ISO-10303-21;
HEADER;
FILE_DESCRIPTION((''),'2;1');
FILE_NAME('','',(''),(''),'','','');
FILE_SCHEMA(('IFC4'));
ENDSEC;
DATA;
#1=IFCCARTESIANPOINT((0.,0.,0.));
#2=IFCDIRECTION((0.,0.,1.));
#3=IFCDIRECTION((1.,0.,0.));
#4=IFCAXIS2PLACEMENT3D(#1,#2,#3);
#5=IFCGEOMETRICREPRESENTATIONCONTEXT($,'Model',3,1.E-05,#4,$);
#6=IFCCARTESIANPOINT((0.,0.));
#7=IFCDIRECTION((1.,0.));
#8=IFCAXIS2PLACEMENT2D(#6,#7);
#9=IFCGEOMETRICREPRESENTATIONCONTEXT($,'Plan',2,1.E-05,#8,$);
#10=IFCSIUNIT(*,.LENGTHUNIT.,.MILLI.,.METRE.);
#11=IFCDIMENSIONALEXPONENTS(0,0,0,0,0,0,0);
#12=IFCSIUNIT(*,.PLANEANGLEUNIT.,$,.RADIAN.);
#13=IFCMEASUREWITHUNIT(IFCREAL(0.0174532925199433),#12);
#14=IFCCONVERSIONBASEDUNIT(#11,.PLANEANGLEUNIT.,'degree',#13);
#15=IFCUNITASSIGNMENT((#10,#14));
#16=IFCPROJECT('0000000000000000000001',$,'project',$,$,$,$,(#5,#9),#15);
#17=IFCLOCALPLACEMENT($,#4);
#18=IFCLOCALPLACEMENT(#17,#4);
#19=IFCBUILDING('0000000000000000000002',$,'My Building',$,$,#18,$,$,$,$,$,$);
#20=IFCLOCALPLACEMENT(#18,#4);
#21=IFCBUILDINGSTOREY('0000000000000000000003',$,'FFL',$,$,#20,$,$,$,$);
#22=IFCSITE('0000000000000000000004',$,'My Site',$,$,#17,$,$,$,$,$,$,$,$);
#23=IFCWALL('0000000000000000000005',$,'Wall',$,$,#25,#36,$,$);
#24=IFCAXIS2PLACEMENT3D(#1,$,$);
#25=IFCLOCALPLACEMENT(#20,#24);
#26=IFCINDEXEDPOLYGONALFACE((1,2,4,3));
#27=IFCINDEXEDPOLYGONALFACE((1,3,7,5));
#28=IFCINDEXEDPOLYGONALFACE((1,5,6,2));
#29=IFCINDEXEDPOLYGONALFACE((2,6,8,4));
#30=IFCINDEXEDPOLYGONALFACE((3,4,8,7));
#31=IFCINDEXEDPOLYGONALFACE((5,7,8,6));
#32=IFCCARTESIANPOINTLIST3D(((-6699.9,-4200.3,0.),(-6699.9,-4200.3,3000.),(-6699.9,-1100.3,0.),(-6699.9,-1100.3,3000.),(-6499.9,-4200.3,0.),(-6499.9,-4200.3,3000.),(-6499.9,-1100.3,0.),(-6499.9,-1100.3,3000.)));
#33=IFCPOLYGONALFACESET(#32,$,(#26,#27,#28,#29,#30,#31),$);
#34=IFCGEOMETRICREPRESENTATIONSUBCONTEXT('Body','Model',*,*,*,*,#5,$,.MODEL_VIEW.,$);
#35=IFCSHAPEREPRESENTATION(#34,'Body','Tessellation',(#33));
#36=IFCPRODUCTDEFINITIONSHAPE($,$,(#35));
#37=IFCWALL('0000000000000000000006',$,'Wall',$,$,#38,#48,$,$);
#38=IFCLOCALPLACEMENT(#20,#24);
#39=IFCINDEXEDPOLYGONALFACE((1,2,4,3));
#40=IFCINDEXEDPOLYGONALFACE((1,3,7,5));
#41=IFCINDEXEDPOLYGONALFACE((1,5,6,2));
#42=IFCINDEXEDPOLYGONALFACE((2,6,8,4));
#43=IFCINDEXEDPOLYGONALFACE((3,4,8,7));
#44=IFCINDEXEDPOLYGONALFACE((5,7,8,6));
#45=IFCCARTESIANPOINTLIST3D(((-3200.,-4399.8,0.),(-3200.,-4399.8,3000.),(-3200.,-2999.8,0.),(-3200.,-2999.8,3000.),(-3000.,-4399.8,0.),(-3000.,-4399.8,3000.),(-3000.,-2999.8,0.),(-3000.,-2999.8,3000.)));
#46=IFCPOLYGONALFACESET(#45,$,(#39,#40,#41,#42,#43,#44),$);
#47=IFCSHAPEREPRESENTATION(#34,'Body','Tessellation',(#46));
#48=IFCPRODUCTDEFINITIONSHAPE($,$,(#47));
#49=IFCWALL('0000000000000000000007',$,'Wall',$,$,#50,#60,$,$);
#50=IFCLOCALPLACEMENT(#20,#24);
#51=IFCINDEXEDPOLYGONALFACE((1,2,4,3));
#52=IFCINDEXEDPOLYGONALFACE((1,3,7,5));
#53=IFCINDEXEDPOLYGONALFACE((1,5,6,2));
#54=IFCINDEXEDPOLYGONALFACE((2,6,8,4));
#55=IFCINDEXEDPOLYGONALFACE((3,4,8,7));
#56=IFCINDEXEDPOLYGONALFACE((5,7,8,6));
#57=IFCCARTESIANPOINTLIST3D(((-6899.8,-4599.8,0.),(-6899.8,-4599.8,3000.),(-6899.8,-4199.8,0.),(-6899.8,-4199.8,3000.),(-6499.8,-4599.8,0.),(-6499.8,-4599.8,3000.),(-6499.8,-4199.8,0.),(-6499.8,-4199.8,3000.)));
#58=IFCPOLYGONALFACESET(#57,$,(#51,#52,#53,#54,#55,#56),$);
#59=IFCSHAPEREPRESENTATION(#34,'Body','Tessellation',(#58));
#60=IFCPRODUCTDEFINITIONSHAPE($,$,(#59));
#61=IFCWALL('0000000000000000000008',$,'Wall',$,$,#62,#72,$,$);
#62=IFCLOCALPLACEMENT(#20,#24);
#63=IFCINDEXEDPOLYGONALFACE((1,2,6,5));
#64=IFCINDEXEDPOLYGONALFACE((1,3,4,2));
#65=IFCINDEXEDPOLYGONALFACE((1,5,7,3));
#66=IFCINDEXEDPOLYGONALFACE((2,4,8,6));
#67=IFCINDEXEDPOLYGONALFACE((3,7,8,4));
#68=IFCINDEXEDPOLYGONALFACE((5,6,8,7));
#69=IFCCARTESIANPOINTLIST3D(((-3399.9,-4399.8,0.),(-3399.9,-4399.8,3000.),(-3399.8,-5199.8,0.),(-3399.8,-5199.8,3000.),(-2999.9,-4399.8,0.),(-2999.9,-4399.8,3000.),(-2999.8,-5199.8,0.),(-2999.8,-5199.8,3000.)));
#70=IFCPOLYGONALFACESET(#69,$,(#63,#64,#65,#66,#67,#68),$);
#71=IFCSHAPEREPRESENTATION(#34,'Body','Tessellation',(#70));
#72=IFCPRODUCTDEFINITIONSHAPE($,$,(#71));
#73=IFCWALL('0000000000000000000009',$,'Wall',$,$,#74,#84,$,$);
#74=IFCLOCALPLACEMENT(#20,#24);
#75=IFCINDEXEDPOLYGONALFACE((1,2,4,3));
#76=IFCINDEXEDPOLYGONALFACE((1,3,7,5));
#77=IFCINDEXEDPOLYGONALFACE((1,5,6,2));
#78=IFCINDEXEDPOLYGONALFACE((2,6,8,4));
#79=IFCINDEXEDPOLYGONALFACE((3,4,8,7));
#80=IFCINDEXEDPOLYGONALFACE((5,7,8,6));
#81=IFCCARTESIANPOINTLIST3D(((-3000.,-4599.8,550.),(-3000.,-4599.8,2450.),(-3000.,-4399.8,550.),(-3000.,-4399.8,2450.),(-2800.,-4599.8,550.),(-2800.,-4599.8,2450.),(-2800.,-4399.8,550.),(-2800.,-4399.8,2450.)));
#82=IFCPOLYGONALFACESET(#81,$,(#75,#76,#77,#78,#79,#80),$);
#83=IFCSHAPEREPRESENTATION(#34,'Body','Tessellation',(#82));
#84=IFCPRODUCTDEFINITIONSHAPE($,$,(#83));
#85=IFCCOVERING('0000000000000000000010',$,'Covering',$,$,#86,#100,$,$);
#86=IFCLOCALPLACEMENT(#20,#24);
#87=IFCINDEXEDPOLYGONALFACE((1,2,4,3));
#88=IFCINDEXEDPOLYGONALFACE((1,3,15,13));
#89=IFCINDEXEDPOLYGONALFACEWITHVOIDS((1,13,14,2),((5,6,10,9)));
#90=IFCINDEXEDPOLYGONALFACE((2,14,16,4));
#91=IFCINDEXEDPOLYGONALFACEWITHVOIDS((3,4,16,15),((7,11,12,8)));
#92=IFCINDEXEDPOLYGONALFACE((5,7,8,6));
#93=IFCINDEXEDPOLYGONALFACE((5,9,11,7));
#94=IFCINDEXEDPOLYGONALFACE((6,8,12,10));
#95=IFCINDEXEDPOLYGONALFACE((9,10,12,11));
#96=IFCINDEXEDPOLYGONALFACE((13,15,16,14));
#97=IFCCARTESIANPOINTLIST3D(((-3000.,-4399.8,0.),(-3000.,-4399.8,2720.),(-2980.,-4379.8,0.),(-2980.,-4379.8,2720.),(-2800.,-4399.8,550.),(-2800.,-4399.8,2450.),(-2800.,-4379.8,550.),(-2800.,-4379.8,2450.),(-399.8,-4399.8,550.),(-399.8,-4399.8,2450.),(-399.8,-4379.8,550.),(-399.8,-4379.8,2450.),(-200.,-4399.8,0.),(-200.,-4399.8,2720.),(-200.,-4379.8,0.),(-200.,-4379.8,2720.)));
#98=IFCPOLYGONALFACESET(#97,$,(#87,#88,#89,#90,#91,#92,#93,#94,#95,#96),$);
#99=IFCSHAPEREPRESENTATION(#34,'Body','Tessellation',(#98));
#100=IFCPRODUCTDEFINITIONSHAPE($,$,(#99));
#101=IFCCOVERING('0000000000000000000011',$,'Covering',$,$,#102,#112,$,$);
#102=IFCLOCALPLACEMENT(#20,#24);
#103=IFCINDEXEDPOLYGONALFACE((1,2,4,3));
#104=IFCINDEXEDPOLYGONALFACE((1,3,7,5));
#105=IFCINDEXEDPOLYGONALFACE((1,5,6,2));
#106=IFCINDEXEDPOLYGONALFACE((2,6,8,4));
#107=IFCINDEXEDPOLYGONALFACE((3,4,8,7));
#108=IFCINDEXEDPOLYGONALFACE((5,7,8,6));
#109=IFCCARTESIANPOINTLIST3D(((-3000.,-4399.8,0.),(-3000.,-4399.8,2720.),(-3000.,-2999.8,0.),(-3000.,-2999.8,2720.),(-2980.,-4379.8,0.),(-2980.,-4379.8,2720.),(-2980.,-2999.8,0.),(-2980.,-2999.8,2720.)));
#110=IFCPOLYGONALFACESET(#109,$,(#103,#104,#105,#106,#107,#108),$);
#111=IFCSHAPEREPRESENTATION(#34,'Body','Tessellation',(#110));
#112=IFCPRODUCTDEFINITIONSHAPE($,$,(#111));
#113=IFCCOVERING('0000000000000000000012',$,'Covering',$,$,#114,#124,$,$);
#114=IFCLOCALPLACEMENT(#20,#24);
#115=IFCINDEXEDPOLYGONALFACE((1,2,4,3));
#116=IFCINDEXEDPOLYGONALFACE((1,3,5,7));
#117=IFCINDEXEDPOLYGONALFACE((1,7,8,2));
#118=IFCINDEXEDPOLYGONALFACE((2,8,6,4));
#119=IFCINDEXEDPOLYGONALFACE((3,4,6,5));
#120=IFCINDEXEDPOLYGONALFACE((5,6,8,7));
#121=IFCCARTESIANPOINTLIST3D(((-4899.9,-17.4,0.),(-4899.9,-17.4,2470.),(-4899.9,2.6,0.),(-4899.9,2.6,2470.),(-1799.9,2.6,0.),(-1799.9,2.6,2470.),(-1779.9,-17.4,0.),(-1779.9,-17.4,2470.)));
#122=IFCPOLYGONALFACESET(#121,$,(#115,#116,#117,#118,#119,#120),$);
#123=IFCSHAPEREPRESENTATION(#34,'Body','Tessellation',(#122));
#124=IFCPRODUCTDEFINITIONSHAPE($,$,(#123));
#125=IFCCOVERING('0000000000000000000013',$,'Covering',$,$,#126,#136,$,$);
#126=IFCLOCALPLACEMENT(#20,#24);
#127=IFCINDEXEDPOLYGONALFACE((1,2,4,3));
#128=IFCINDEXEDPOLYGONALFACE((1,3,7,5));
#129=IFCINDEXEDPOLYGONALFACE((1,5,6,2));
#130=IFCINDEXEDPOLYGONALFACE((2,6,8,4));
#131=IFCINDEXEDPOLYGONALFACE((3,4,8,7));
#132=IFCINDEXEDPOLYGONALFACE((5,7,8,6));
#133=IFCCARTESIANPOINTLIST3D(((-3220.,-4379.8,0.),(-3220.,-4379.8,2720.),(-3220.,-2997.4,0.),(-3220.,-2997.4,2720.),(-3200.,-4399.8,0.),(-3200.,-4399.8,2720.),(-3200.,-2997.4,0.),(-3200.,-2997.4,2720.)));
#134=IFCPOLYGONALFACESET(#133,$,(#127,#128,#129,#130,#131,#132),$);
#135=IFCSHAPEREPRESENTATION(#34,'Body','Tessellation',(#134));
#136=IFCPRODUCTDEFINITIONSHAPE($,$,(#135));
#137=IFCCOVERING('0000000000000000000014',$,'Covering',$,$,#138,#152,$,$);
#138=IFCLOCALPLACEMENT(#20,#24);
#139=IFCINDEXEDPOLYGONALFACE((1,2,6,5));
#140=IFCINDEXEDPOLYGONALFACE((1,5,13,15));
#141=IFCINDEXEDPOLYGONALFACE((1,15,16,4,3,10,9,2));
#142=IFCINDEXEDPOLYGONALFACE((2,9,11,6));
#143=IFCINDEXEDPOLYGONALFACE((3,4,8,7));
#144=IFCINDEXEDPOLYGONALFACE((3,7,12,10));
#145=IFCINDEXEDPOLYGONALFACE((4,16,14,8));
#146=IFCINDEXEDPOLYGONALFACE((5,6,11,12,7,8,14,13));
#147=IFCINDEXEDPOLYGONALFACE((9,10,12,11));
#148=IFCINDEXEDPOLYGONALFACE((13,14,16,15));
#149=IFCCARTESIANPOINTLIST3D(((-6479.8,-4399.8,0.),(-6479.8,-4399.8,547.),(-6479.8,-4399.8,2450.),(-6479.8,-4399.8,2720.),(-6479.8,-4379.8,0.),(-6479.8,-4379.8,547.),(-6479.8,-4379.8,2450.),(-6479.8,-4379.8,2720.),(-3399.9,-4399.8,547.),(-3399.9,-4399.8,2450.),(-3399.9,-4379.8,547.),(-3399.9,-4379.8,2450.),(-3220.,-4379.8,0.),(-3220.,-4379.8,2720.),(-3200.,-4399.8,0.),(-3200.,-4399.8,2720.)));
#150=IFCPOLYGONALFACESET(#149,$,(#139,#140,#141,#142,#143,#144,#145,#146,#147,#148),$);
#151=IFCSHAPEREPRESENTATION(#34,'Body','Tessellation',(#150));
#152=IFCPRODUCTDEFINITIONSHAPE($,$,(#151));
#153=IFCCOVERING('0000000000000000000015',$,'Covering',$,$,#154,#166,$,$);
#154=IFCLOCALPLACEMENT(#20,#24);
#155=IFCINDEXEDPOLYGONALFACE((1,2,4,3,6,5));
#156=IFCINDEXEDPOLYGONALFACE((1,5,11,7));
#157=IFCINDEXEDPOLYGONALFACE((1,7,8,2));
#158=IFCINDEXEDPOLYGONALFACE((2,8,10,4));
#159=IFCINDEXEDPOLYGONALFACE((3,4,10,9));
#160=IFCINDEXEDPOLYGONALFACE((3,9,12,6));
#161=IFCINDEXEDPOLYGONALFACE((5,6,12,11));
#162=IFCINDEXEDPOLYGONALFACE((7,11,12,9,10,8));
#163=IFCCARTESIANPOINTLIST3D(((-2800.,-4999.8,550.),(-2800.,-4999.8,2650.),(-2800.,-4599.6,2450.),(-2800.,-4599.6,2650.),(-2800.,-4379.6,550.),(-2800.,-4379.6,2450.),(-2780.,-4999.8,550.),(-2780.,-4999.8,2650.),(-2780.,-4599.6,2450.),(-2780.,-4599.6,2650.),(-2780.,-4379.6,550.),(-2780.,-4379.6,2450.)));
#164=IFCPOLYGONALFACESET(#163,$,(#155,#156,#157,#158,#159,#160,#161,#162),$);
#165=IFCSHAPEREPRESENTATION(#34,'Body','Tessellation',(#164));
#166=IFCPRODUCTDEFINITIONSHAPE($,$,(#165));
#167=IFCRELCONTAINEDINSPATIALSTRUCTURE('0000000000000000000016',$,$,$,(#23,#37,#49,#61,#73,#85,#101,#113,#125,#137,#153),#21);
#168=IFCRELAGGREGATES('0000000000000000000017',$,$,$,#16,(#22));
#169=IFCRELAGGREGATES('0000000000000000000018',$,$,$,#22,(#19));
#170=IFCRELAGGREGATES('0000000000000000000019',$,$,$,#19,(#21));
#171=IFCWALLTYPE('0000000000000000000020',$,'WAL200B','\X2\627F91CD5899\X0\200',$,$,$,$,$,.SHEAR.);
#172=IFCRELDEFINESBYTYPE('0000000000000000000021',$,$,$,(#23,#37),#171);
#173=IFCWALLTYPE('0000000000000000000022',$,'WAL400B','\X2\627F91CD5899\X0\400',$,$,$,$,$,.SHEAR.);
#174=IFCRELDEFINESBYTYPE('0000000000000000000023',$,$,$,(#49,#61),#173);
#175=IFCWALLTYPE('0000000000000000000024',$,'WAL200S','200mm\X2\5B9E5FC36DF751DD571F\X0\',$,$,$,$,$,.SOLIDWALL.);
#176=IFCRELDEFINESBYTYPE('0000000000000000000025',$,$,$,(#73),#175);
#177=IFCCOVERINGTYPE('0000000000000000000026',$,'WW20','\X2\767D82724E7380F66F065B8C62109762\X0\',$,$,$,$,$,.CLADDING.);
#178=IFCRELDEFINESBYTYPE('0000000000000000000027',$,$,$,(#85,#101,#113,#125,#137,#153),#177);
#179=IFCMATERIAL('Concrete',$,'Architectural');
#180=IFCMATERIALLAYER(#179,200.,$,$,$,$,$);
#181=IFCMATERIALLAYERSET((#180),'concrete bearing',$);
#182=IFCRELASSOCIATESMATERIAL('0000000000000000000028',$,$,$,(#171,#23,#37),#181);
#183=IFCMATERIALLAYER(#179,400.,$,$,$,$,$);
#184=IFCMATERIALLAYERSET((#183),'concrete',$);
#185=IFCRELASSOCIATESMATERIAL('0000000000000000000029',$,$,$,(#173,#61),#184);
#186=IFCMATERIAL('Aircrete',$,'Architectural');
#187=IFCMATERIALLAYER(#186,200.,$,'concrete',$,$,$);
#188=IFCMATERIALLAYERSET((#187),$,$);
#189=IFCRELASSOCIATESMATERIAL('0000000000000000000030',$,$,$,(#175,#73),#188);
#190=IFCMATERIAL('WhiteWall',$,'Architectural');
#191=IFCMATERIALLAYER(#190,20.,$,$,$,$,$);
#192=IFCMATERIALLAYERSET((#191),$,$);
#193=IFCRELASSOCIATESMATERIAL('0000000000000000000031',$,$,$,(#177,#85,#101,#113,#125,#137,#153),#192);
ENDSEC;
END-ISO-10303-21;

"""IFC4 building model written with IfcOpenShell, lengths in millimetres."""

from ifc_helpers import new_model, entity, si_unit, converted_unit, frame, origin_with_axes, origin_2d_with_axis, place, context, subcontext, project, spatial, line, indexed_curve, outline, extrude, material, layer, layer_set, layer_usage, type_object, element, save


model = new_model("IFC4")

# Units and contexts
model_context = context("Model", 3, precision=1e-05, world=origin_with_axes())
plan_context = context("Plan", 2, precision=1e-05, world=origin_2d_with_axis())
body_context_1 = subcontext(model_context, "Body", "Model", "MODEL_VIEW")
ifc_project = project(units=[si_unit("LENGTHUNIT", "METRE", prefix="MILLI"), converted_unit("PLANEANGLEUNIT", "degree", entity("IfcReal", 0.0174532925199433), si_unit("PLANEANGLEUNIT", "RADIAN"), dimensions=[0, 0, 0, 0, 0, 0, 0])], contexts=[model_context, plan_context])

# Site, building, storey
site_placement = place(None, origin_with_axes())
site = spatial("IfcSite", under=ifc_project, at=site_placement, Name="My Site")
building_placement = place(site_placement, origin_with_axes())
building = spatial("IfcBuilding", under=site, at=building_placement, Name="My Building")
storey_placement = place(building_placement, origin_with_axes())
storey = spatial("IfcBuildingStorey", under=building, at=storey_placement, Name="FFL")

# Shared definitions
ifc_material_1 = material(Name="Aircrete", Category="Architectural")

# Walls
ifc_material_2 = material(Name="Concrete", Category="Architectural")
ifc_layer_1 = layer(ifc_material_2, 200.0)
ifc_layer_set_1 = layer_set([ifc_layer_1], Name="concrete bearing")
wall_type_1 = type_object("IfcWallType", Name="WAL200B", Description="承重墙200", PredefinedType="SHEAR", material=ifc_layer_set_1)
ifc_layer_usage_1 = layer_usage(ifc_layer_set_1, "AXIS2", "NEGATIVE", 0.0)
wall_1_placement = place(storey_placement, frame((-6499.9, -1100.3, 0.0), z_axis=(0.0, 0.0, 1.0), x_axis=(0.0, -1.0, 0.0)))
element("IfcWall", 1, at=wall_1_placement, inside=storey, type_object=wall_type_1, material=ifc_layer_usage_1, Name="Wall", context=body_context_1, shape_type="SweptSolid", body=[
    extrude(outline(indexed_curve([(0.0, -200.0), (0.0, 0.0), (3100.0, 0.0), (3100.0, -200.0)], segments=[line(1, 2, 3, 4, 1)])), origin_with_axes(), (0.0, 0.0, 1.0), 3000.0),
])
ifc_layer_usage_2 = layer_usage(ifc_layer_set_1, "AXIS2", "NEGATIVE", 0.0)
wall_2_placement = place(storey_placement, frame((-3200.0, -4399.8, 0.0), z_axis=(0.0, 0.0, 1.0), x_axis=(0.000007, 1.0, 0.0)))
element("IfcWall", 2, at=wall_2_placement, inside=storey, type_object=wall_type_1, material=ifc_layer_usage_2, Name="Wall", context=body_context_1, shape_type="SweptSolid", body=[
    extrude(outline(indexed_curve([(0.0, -200.0), (0.0, 0.0), (1400.0, 0.0), (1400.0, -200.0)], segments=[line(1, 2, 3, 4, 1)])), origin_with_axes(), (0.0, 0.0, 1.0), 3000.0),
])
ifc_layer_2 = layer(ifc_material_2, 400.0)
ifc_layer_set_2 = layer_set([ifc_layer_2], Name="concrete")
wall_type_2 = type_object("IfcWallType", Name="WAL400B", Description="承重墙400", PredefinedType="SHEAR", material=ifc_layer_set_2)
wall_3_placement = place(storey_placement, frame((-6499.8, -4599.8, 0.0), z_axis=(0.0, 0.0, 1.0), x_axis=(0.0, 1.0, 0.0)))
element("IfcWall", 3, at=wall_3_placement, inside=storey, type_object=wall_type_2, Name="Wall", context=body_context_1, shape_type="SweptSolid", body=[
    extrude(outline(indexed_curve([(0.0, 0.0), (0.0, 400.0), (400.0, 400.0), (400.0, 0.0), (0.0, 0.0)])), origin_with_axes(), (0.0, 0.0, 1.0), 3000.0),
])
ifc_layer_usage_3 = layer_usage(ifc_layer_set_2, "AXIS2", "POSITIVE", 0.0)
wall_4_placement = place(storey_placement, frame((-3399.9, -4399.8, 0.0), z_axis=(0.0, 0.0, 1.0), x_axis=(0.000114, -1.0, 0.0)))
element("IfcWall", 4, at=wall_4_placement, inside=storey, type_object=wall_type_2, material=ifc_layer_usage_3, Name="Wall", context=body_context_1, shape_type="SweptSolid", body=[
    extrude(outline(indexed_curve([(0.0, 0.0), (0.0, 400.0), (800.0, 400.0), (800.0, 0.0)], segments=[line(1, 2, 3, 4, 1)])), origin_with_axes(), (0.0, 0.0, 1.0), 3000.0),
])
ifc_layer_3 = layer(ifc_material_1, 200.0, Name="concrete")
ifc_layer_set_3 = layer_set([ifc_layer_3])
ifc_layer_usage_4 = layer_usage(ifc_layer_set_3, "AXIS2", "NEGATIVE", 0.0)
wall_type_3 = type_object("IfcWallType", Name="WAL200S", Description="200mm实心混凝土", PredefinedType="SOLIDWALL", material=ifc_layer_set_3)
wall_5_placement = place(storey_placement, frame((-2800.0, -4399.8, 550.0), z_axis=(0.0, 0.0, 1.0), x_axis=(0.000002, -1.0, 0.0)))
element("IfcWall", 5, at=wall_5_placement, inside=storey, type_object=wall_type_3, material=ifc_layer_usage_4, Name="Wall", context=body_context_1, shape_type="SweptSolid", body=[
    extrude(outline(indexed_curve([(0.0, -200.0), (0.0, 0.0), (200.0, 0.0), (200.0, -200.0)], segments=[line(1, 2, 3, 4, 1)])), origin_with_axes(), (0.0, 0.0, 1.0), 1900.0),
])

# Covering, opening
ifc_material_3 = material(Name="WhiteWall", Category="Architectural")
ifc_layer_4 = layer(ifc_material_3, 20.0)
ifc_layer_set_4 = layer_set([ifc_layer_4])
ifc_layer_usage_5 = layer_usage(ifc_layer_set_4, "AXIS2", "POSITIVE", 0.0)
covering_type = type_object("IfcCoveringType", Name="WW20", Description="白色乳胶漆完成面", PredefinedType="CLADDING", material=ifc_layer_set_4)
covering_1_placement = place(storey_placement, frame((-3000.0, -4399.8, 0.0), z_axis=(0.0, 0.0, 1.0), x_axis=(1.0, -0.000001, 0.0)))
covering_1 = element("IfcCovering", 6, at=covering_1_placement, inside=storey, type_object=covering_type, material=ifc_layer_usage_5, Name="Covering", context=body_context_1, shape_type="SweptSolid", body=[
    extrude(outline(indexed_curve([(0.0, 0.0), (20.0, 20.0), (2800.0, 20.0), (2800.0, 0.0)], segments=[line(1, 2, 3, 4, 1)])), origin_with_axes(), (0.0, 0.0, 1.0), 2720.0),
])
opening_1_placement = place(covering_1_placement, frame((200.0, 300.0, 550.0), z_axis=(0.000001, -1.0, 0.0), x_axis=(1.0, 0.000001, 0.0)))
element("IfcOpeningElement", 7, at=opening_1_placement, cuts=covering_1, PredefinedType="OPENING", context=body_context_1, shape_type="SweptSolid", body=[
    extrude(outline(indexed_curve([(0.0, 0.0), (2400.2, 0.0), (2400.2, 1900.0), (0.0, 1900.0), (0.0, 0.0)])), origin_with_axes(), (0.0, 0.0, 1.0), 500.0),
])

# Coverings
ifc_layer_usage_6 = layer_usage(ifc_layer_set_4, "AXIS2", "POSITIVE", 0.0)
covering_2_placement = place(storey_placement, frame((-3000.0, -2999.8, 0.0), z_axis=(0.0, 0.0, 1.0), x_axis=(-0.000001, -1.0, 0.0)))
element("IfcCovering", 8, at=covering_2_placement, inside=storey, type_object=covering_type, material=ifc_layer_usage_6, Name="Covering", context=body_context_1, shape_type="SweptSolid", body=[
    extrude(outline(indexed_curve([(0.0, 0.0), (0.0, 20.0), (1380.0, 20.0), (1400.0, 0.0)], segments=[line(1, 2, 3, 4, 1)])), origin_with_axes(), (0.0, 0.0, 1.0), 2720.0),
])
ifc_layer_usage_7 = layer_usage(ifc_layer_set_4, "AXIS2", "POSITIVE", 0.0)
covering_3_placement = place(storey_placement, frame((-1799.9, 2.6, 0.0), z_axis=(0.0, 0.0, 1.0), x_axis=(-1.0, 0.000002, 0.0)))
element("IfcCovering", 9, at=covering_3_placement, inside=storey, type_object=covering_type, material=ifc_layer_usage_7, Name="Covering", context=body_context_1, shape_type="SweptSolid", body=[
    extrude(outline(indexed_curve([(0.0, 0.0), (-20.0, 20.0), (3100.0, 20.0), (3100.0, 0.0)], segments=[line(1, 2, 3, 4, 1)])), origin_with_axes(), (0.0, 0.0, 1.0), 2470.0),
])
ifc_layer_usage_8 = layer_usage(ifc_layer_set_4, "AXIS2", "NEGATIVE", 0.0)
covering_4_placement = place(storey_placement, frame((-3200.0, -2997.4, 0.0), z_axis=(0.0, 0.0, 1.0), x_axis=(-0.000001, -1.0, 0.0)))
element("IfcCovering", 10, at=covering_4_placement, inside=storey, type_object=covering_type, material=ifc_layer_usage_8, Name="Covering", context=body_context_1, shape_type="SweptSolid", body=[
    extrude(outline(indexed_curve([(0.0, -20.0), (0.0, 0.0), (1402.4, 0.0), (1382.4, -20.0)], segments=[line(1, 2, 3, 4, 1)])), origin_with_axes(), (0.0, 0.0, 1.0), 2720.0),
])

# Coverings, openings
ifc_layer_usage_9 = layer_usage(ifc_layer_set_4, "AXIS2", "POSITIVE", 0.0)
covering_5_placement = place(storey_placement, frame((-6499.8, -4399.8, 0.0), z_axis=(0.0, 0.0, 1.0), x_axis=(1.0, -0.000001, 0.0)))
covering_5 = element("IfcCovering", 11, at=covering_5_placement, inside=storey, type_object=covering_type, material=ifc_layer_usage_9, Name="Covering", context=body_context_1, shape_type="SweptSolid", body=[
    extrude(outline(indexed_curve([(20.0, 0.0), (20.0, 20.0), (3279.8, 20.0), (3299.8, 0.0)], segments=[line(1, 2, 3, 4, 1)])), origin_with_axes(), (0.0, 0.0, 1.0), 2720.0),
])
opening_2_placement = place(covering_5_placement, frame((0.0, 200.0, 547.0), z_axis=(0.000001, -1.0, 0.0), x_axis=(1.0, 0.000001, 0.0)))
element("IfcOpeningElement", 12, at=opening_2_placement, cuts=covering_5, PredefinedType="OPENING", context=body_context_1, shape_type="SweptSolid", body=[
    extrude(outline(indexed_curve([(0.0, 0.0), (3099.9, 0.0), (3099.9, 1903.0), (0.0, 1903.0), (0.0, 0.0)])), origin_with_axes(), (0.0, 0.0, 1.0), 500.0),
])
ifc_layer_usage_10 = layer_usage(ifc_layer_set_4, "AXIS2", "NEGATIVE", 0.0)
covering_6_placement = place(storey_placement, frame((-2800.0, -4999.8, 550.0), z_axis=(0.0, 0.0, 1.0), x_axis=(0.000001, 1.0, 0.0)))
covering_6 = element("IfcCovering", 13, at=covering_6_placement, inside=storey, type_object=covering_type, material=ifc_layer_usage_10, Name="Covering", context=body_context_1, shape_type="SweptSolid", body=[
    extrude(outline(indexed_curve([(0.0, -20.0), (0.0, 0.0), (620.2, 0.0), (620.2, -20.0)], segments=[line(1, 2, 3, 4, 1)])), origin_with_axes(), (0.0, 0.0, 1.0), 2100.0),
])
opening_3_placement = place(covering_6_placement, frame((620.2, 120.0, 1900.0), z_axis=(0.000001, -1.0, 0.0), x_axis=(0.0, 0.0, 1.0)))
element("IfcOpeningElement", 14, at=opening_3_placement, cuts=covering_6, PredefinedType="OPENING", context=body_context_1, shape_type="SweptSolid", body=[
    extrude(outline(indexed_curve([(0.0, 220.0), (500.0, 220.0), (500.0, -100.0), (0.0, -100.0), (0.0, 220.0)])), origin_with_axes(), (0.0, 0.0, 1.0), 500.0),
])

save(model, "model.ifc")
